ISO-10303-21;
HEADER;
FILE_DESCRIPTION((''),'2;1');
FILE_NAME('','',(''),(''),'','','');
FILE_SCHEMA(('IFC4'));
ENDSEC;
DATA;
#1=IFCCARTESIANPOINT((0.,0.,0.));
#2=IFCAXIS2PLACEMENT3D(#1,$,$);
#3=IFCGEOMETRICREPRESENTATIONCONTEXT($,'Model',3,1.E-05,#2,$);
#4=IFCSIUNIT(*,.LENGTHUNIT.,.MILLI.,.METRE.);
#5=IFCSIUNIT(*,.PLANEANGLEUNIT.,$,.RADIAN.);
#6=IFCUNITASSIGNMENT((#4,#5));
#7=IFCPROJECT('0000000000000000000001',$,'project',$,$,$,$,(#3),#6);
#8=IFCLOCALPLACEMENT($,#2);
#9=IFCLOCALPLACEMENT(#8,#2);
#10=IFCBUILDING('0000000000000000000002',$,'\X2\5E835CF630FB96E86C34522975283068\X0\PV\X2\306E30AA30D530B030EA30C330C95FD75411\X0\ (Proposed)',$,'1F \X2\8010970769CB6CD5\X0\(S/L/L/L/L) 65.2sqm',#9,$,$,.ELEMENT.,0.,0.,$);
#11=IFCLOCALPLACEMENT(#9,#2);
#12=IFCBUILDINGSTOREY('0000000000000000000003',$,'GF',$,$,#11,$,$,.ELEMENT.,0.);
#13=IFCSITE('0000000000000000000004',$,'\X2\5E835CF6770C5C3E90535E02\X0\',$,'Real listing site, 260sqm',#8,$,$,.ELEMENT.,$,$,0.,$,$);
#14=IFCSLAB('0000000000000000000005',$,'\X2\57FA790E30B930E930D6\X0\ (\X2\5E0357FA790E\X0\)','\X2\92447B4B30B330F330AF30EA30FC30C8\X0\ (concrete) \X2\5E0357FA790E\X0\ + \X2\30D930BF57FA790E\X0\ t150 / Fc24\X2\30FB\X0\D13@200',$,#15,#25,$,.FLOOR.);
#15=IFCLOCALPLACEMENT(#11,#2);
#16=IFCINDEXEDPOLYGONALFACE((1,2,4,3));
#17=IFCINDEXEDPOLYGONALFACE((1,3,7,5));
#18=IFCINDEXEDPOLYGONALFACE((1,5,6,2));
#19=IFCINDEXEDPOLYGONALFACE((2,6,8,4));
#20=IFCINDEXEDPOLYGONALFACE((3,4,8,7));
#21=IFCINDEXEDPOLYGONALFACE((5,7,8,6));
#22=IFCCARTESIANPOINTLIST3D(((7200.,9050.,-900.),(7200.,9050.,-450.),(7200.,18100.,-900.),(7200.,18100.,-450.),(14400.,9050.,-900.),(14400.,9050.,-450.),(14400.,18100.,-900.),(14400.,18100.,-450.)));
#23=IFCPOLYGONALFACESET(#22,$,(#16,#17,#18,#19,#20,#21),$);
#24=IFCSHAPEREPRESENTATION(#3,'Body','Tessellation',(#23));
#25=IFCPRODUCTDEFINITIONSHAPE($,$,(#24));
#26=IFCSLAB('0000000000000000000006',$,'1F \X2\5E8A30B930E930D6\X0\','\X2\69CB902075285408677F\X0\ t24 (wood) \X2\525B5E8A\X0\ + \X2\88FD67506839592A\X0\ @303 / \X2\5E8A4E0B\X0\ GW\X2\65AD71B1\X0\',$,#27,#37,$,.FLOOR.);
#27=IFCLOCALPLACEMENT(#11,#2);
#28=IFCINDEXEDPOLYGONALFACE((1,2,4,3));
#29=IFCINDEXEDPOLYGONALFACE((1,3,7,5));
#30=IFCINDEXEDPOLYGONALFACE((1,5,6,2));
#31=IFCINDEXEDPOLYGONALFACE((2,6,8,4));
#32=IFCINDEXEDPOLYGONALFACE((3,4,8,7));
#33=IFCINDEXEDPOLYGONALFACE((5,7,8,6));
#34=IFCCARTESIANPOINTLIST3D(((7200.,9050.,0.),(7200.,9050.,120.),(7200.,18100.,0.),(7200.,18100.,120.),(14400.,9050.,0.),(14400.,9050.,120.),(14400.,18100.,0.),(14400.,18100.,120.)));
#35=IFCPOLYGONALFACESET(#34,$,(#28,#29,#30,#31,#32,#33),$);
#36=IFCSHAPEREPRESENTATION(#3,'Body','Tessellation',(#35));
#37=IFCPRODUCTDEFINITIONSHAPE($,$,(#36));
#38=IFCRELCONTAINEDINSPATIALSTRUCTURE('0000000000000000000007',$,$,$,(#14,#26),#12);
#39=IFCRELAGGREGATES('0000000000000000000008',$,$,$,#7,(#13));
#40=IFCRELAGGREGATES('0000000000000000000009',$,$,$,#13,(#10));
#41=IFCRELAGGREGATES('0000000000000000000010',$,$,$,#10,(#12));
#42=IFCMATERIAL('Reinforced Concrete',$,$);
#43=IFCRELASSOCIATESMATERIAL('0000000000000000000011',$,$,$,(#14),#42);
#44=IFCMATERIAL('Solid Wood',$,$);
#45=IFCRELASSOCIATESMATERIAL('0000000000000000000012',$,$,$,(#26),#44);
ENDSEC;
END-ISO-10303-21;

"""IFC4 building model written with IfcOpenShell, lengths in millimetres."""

from ifc_helpers import new_model, si_unit, frame, frame_2d, origin, place, context, project, spatial, rectangle, extrude, material, element, save


model = new_model("IFC4")

# Units and contexts
model_context = context("Model", 3, precision=1e-05, world=origin())
ifc_project = project(units=[si_unit("LENGTHUNIT", "METRE", prefix="MILLI"), si_unit("PLANEANGLEUNIT", "RADIAN")], contexts=[model_context])

# Site, building, storey
site_placement = place(None, origin())
site = spatial("IfcSite", under=ifc_project, at=site_placement, Name="広島県尾道市", ObjectType="Real listing site, 260sqm", CompositionType="ELEMENT", RefElevation=0.0)
building_placement = place(site_placement, origin())
building = spatial("IfcBuilding", under=site, at=building_placement, Name="広島・雨水利用とPVのオフグリッド志向 (Proposed)", ObjectType="1F 耐震構法(S/L/L/L/L) 65.2sqm", CompositionType="ELEMENT", ElevationOfRefHeight=0.0, ElevationOfTerrain=0.0)
storey_placement = place(building_placement, origin())
storey = spatial("IfcBuildingStorey", under=building, at=storey_placement, Name="GF", CompositionType="ELEMENT", Elevation=0.0)

# Shared definitions
ifc_material_1 = material(Name="Solid Wood")

# Slabs
ifc_material_2 = material(Name="Reinforced Concrete")
slab_1_placement = place(storey_placement, frame((3600.0, 4525.0, -450.0)))
element("IfcSlab", 1, at=slab_1_placement, inside=storey, material=ifc_material_2, Name="基礎スラブ (布基礎)", Description="鉄筋コンクリート (concrete) 布基礎 + ベタ基礎 t150 / Fc24・D13@200", PredefinedType="FLOOR", context=model_context, shape_type="SweptSolid", body=[
    extrude(rectangle(XDim=7200.0, YDim=9050.0, at=frame_2d((3600.0, 4525.0))), frame((3600.0, 4525.0, -450.0)), (0.0, 0.0, 1.0), 450.0),
])
slab_2_placement = place(storey_placement, frame((3600.0, 4525.0, 0.0)))
element("IfcSlab", 2, at=slab_2_placement, inside=storey, material=ifc_material_1, Name="1F 床スラブ", Description="構造用合板 t24 (wood) 剛床 + 製材根太 @303 / 床下 GW断熱", PredefinedType="FLOOR", context=model_context, shape_type="SweptSolid", body=[
    extrude(rectangle(XDim=7200.0, YDim=9050.0, at=frame_2d((3600.0, 4525.0))), frame((3600.0, 4525.0, 0.0)), (0.0, 0.0, 1.0), 120.0),
])

save(model, "model.ifc")
